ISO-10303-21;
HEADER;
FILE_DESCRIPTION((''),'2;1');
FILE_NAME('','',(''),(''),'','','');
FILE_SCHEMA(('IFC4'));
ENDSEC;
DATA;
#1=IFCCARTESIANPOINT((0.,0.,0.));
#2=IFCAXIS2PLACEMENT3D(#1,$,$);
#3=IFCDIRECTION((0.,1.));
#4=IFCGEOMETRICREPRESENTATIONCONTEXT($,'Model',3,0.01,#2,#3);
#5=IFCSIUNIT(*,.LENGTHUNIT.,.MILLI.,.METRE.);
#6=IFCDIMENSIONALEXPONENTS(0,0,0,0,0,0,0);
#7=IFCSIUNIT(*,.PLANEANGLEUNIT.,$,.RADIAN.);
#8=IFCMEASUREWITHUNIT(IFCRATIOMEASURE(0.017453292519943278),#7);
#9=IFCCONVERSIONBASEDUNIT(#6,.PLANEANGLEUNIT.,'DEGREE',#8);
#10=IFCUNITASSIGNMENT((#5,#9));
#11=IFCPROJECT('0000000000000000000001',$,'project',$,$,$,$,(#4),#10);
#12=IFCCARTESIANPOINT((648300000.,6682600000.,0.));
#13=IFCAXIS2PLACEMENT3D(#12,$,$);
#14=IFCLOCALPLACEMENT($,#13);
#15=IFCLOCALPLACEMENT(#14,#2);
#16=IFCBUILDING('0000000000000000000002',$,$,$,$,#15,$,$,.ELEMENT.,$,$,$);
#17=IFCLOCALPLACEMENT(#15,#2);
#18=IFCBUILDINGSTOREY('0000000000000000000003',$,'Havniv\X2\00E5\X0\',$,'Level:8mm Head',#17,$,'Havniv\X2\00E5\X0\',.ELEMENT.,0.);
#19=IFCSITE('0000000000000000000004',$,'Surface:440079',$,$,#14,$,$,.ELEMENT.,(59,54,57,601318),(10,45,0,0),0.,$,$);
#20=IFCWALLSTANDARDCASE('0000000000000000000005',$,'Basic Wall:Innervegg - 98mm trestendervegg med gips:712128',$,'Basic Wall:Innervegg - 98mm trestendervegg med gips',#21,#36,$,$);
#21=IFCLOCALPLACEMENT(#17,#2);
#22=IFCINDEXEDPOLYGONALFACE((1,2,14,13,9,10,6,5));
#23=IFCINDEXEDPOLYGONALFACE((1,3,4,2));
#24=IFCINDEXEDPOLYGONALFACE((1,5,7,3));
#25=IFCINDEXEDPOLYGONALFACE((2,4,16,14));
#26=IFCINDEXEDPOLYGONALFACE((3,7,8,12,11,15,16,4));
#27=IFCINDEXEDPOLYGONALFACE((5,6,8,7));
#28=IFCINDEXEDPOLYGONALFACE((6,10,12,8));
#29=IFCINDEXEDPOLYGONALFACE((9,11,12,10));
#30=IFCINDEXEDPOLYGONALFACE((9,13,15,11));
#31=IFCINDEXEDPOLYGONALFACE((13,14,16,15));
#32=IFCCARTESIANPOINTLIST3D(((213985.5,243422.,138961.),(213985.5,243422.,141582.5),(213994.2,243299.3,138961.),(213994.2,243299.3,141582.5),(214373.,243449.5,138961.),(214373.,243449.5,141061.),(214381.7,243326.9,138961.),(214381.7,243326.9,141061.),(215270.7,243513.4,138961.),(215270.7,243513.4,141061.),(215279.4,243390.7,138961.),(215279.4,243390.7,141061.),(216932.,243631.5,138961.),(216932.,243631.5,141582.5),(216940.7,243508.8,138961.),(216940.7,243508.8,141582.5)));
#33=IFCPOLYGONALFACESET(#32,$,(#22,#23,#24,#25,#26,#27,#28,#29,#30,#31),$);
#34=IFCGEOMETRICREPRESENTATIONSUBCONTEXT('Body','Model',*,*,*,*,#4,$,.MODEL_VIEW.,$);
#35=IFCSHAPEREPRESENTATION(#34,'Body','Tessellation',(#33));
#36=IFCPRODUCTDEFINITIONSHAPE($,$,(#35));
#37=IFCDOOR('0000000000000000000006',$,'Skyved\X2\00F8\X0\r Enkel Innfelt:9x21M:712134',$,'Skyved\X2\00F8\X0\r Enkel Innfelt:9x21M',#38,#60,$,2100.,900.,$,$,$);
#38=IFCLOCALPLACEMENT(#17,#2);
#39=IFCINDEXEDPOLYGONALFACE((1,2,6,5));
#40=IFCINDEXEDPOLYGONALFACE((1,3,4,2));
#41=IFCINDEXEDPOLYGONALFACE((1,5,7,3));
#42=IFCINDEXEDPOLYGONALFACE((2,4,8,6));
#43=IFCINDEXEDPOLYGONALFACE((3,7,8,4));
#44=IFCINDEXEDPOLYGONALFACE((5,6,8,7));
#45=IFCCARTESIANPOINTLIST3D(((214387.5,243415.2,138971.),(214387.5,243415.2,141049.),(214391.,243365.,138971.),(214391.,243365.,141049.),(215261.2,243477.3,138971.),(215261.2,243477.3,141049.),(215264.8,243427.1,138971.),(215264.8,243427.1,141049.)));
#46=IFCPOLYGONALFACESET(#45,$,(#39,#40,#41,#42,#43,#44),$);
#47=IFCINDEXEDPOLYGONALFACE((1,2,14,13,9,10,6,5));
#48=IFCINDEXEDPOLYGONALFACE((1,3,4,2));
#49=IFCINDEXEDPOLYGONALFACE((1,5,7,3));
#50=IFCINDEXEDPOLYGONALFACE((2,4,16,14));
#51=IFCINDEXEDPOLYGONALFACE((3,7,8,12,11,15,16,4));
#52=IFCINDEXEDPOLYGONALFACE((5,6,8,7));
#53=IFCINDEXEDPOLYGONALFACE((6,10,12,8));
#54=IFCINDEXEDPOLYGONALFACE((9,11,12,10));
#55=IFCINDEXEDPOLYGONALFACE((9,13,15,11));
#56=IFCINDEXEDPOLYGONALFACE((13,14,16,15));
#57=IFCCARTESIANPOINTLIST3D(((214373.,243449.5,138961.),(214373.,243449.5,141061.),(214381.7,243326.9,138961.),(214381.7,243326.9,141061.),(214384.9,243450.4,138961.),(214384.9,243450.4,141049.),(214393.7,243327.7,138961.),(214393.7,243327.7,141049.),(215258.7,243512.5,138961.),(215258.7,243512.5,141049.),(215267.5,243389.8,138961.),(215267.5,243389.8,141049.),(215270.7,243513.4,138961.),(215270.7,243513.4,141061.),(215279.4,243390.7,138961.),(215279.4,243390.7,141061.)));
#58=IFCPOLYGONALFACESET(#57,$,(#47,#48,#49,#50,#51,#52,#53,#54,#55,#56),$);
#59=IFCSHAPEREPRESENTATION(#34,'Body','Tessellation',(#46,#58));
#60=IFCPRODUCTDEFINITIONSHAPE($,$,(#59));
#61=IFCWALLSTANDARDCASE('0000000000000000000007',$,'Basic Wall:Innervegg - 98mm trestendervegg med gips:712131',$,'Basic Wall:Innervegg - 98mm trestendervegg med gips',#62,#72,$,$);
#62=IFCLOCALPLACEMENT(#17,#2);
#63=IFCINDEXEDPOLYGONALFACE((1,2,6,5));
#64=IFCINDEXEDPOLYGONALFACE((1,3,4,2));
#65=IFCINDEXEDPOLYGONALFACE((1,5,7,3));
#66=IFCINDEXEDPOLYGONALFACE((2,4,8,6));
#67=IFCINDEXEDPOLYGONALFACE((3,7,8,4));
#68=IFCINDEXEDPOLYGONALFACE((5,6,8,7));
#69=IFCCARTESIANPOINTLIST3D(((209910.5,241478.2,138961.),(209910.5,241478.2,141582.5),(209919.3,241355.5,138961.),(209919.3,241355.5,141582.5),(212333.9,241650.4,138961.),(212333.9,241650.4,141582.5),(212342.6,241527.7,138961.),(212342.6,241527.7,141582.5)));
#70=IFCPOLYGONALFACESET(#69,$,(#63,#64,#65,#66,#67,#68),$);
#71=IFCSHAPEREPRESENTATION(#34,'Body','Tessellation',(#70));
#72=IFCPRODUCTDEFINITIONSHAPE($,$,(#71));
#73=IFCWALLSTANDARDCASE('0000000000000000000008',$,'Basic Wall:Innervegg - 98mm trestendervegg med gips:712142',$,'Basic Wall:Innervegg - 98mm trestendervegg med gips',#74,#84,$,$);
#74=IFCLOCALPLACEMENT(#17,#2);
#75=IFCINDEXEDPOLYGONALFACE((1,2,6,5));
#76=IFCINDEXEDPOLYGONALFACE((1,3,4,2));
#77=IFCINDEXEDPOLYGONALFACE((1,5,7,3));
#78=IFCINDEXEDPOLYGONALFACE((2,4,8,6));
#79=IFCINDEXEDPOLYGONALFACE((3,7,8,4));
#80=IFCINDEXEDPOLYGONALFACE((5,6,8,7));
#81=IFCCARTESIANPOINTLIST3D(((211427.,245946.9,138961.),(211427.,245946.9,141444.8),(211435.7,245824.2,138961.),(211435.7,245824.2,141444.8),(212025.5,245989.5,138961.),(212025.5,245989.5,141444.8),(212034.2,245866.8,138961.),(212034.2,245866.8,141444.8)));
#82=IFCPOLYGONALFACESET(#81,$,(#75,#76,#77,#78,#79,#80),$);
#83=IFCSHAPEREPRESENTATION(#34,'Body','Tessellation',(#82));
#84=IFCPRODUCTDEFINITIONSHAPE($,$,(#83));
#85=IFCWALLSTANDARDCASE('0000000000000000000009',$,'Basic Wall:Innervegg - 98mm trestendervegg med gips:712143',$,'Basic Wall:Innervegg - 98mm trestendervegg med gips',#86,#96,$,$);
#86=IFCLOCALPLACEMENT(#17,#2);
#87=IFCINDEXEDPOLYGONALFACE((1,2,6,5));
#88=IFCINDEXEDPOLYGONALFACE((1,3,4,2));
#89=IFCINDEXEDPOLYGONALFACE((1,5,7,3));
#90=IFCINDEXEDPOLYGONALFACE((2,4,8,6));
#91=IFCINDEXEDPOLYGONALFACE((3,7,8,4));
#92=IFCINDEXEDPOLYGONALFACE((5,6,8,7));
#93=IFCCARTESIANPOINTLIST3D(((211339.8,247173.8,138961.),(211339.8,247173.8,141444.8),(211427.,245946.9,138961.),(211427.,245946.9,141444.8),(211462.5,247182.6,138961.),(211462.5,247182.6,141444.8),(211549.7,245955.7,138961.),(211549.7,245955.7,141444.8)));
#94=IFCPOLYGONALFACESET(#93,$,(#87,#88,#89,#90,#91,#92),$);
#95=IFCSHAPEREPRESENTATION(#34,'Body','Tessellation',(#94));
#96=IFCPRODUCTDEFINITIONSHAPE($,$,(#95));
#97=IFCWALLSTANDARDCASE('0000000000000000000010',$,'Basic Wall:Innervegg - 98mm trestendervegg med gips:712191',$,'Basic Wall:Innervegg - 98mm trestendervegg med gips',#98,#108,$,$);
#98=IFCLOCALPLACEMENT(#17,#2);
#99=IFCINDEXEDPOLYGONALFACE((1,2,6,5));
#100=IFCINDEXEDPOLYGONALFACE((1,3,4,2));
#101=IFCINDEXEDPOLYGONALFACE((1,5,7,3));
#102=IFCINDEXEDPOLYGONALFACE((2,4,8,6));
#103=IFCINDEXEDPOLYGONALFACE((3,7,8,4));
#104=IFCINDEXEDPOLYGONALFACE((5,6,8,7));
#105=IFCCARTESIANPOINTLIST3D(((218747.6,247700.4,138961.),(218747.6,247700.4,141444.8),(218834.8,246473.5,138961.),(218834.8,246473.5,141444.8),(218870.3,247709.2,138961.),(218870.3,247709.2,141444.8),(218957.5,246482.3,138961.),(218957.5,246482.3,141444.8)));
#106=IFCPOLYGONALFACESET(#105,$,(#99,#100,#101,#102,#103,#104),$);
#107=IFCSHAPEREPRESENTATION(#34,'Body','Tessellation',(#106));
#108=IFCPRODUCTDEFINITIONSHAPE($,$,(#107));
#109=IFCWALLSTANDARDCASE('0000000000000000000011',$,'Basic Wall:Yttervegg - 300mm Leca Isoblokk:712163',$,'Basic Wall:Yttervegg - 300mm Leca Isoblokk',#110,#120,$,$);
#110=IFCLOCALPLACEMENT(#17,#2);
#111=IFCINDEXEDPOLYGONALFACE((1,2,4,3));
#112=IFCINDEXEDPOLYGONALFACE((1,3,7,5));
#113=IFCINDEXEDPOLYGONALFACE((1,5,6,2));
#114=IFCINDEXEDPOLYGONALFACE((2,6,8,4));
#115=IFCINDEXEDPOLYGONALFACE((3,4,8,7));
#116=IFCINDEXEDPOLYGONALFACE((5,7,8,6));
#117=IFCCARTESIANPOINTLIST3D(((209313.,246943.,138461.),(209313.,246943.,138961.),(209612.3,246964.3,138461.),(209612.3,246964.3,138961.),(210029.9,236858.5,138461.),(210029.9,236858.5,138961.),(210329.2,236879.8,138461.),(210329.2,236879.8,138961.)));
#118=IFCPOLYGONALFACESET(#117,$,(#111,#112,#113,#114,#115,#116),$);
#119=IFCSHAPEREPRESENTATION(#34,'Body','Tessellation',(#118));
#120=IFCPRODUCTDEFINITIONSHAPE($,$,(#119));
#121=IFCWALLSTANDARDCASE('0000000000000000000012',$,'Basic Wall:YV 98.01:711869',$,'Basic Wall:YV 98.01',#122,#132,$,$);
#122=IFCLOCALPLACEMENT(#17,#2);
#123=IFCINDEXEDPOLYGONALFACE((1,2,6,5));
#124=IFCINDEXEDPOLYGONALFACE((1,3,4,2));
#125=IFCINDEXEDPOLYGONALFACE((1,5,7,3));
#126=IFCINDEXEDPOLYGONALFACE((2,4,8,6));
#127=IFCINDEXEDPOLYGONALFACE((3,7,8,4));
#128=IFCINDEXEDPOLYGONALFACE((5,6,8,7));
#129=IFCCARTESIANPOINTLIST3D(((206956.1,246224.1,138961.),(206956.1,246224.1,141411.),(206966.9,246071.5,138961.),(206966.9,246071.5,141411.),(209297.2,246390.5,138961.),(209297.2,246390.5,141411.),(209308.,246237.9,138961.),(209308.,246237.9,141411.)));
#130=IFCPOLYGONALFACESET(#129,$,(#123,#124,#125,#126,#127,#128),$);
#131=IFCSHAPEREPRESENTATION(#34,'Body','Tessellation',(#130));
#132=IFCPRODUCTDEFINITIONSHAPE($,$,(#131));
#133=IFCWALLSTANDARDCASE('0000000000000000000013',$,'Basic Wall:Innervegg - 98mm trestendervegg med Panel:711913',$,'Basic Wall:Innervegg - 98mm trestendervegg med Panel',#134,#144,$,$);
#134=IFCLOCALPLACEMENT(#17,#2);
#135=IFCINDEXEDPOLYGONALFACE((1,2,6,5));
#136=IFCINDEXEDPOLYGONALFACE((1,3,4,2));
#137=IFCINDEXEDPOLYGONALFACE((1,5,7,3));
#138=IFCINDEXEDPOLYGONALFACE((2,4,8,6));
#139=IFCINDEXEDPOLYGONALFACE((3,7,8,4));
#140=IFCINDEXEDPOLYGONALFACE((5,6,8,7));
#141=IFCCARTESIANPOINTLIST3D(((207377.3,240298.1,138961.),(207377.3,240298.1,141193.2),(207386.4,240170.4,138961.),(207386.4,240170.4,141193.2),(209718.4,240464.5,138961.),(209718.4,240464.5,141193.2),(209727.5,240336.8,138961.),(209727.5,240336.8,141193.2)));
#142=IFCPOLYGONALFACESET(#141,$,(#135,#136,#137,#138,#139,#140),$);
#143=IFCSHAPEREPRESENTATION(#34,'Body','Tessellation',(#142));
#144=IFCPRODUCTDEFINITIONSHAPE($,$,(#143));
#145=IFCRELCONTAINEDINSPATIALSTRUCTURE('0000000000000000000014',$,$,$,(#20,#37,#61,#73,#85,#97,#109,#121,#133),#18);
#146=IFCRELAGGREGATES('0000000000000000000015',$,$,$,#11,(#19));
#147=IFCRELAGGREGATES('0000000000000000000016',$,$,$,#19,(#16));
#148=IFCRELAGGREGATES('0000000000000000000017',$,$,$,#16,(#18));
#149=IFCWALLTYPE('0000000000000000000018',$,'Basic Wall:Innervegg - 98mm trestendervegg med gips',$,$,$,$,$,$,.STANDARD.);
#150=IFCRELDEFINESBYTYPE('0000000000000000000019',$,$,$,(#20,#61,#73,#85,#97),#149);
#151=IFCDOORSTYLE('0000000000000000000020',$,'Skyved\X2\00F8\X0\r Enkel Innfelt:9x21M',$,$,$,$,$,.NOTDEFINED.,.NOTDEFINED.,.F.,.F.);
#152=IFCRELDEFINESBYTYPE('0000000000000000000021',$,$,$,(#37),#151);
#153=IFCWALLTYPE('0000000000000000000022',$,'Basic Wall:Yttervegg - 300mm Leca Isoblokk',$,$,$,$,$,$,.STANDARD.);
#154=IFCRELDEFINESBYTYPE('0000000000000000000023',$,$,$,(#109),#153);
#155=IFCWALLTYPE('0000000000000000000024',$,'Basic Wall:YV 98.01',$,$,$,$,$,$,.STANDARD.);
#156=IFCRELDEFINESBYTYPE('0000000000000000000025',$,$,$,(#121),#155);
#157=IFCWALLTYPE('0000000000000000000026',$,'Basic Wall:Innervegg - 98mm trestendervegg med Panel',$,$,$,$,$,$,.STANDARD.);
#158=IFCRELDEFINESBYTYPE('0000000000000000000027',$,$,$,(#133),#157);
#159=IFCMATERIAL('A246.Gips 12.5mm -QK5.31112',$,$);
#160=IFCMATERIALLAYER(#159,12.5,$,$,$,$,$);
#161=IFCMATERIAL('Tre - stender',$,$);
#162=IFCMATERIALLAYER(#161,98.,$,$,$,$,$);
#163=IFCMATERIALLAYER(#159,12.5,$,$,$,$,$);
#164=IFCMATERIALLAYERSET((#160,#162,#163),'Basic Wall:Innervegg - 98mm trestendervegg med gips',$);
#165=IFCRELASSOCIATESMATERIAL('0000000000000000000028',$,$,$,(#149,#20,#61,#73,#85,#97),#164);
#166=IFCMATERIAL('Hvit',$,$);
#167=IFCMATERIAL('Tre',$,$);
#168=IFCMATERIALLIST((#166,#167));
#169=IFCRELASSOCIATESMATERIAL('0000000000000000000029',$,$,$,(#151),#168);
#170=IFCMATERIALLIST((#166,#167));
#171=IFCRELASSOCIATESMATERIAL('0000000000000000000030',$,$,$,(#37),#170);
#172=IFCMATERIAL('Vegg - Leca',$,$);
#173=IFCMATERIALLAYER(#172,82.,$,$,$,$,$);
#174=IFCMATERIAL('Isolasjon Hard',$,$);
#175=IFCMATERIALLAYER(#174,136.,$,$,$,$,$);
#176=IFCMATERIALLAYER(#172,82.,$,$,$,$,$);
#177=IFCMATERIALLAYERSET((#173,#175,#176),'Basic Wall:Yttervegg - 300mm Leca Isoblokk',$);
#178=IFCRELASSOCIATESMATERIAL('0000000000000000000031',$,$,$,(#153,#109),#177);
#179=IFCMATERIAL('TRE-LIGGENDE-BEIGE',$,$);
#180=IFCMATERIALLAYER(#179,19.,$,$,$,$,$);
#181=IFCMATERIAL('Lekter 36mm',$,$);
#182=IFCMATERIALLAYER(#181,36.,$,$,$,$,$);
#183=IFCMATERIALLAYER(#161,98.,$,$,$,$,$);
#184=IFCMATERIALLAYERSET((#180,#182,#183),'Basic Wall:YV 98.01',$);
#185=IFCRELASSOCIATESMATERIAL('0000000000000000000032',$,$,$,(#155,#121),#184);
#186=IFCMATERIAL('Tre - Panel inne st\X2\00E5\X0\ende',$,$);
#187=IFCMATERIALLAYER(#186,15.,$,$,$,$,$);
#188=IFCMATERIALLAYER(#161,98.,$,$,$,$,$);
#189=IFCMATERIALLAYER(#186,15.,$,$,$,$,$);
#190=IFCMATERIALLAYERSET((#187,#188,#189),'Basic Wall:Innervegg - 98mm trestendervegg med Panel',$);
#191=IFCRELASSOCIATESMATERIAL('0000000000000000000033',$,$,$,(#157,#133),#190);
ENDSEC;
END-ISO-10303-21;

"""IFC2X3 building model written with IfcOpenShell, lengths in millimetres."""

from ifc_helpers import new_model, entity, si_unit, converted_unit, direction, frame, frame_2d, origin, place, context, subcontext, project, spatial, polyline, rectangle, outline, extrude, clip, bounded_halfspace, source, transform, mapped, material, material_list, layer, layer_set, layer_usage, type_object, type_shapes, element, fill, save


model = new_model("IFC2X3")

# Units and contexts
model_context = context("Model", 3, precision=0.01, world=origin(), true_north=direction((0.0, 1.0)))
body_context = subcontext(model_context, "Body", "Model", "MODEL_VIEW")
ifc_project = project(units=[si_unit("LENGTHUNIT", "METRE", prefix="MILLI"), converted_unit("PLANEANGLEUNIT", "DEGREE", entity("IfcRatioMeasure", 0.017453292519943278), si_unit("PLANEANGLEUNIT", "RADIAN"), dimensions=[0, 0, 0, 0, 0, 0, 0])], contexts=[model_context])

# Site, building, storey
site_placement = place(None, frame((648300000.0, 6682600000.0, 0.0)))
site = spatial("IfcSite", under=ifc_project, at=site_placement, Name="Surface:440079", CompositionType="ELEMENT", RefLatitude=(59, 54, 57, 601318), RefLongitude=(10, 45, 0, 0), RefElevation=0.0)
building_placement = place(site_placement, origin())
building = spatial("IfcBuilding", under=site, at=building_placement, CompositionType="ELEMENT")
storey_placement = place(building_placement, origin())
storey = spatial("IfcBuildingStorey", under=building, at=storey_placement, Name="Havnivå", ObjectType="Level:8mm Head", LongName="Havnivå", CompositionType="ELEMENT", Elevation=0.0)

# Shared definitions
ifc_material_1 = material(Name="TRE-LIGGENDE-BEIGE")
ifc_material_2 = material(Name="Lekter 36mm")
ifc_material_3 = material(Name="A246.Gips 12.5mm -QK5.31112")

# Shared definitions
ifc_layer_1 = layer(ifc_material_3, 12.5)
ifc_material_4 = material(Name="Tre - stender")
ifc_layer_2 = layer(ifc_material_4, 98.0)
ifc_layer_3 = layer(ifc_material_3, 12.5)
ifc_layer_set_1 = layer_set([ifc_layer_1, ifc_layer_2, ifc_layer_3], Name="Basic Wall:Innervegg - 98mm trestendervegg med gips")
wall_type_1 = type_object("IfcWallType", Name="Basic Wall:Innervegg - 98mm trestendervegg med gips", PredefinedType="STANDARD", material=ifc_layer_set_1)
ifc_material_5 = material(Name="Hvit")
ifc_material_6 = material(Name="Tre")

# Wall, opening, door
ifc_layer_usage_1 = layer_usage(ifc_layer_set_1, "AXIS2", "POSITIVE", -61.5)
wall_1_placement = place(storey_placement, frame((213989.8, 243360.7, 138961.0), z_axis=(0.0, 0.0, 1.0), x_axis=(0.997483, 0.070908, 0.0)))
wall_1 = element("IfcWallStandardCase", 1, at=wall_1_placement, inside=storey, type_object=wall_type_1, material=ifc_layer_usage_1, Name="Basic Wall:Innervegg - 98mm trestendervegg med gips:712128", ObjectType="Basic Wall:Innervegg - 98mm trestendervegg med gips", context=body_context, shape_type="SweptSolid", body=[
    extrude(rectangle(XDim=2954.0, YDim=123.0, at=frame_2d((1477.0, 0.0), x_axis=(1.0, 0.0))), origin(), (0.0, 0.0, 1.0), 2621.5),
])
opening_1_placement = place(wall_1_placement, frame((388.5, -61.5, 0.0)))
opening_1 = element("IfcOpeningElement", 2, at=opening_1_placement, cuts=wall_1, ObjectType="Opening", context=body_context, shape_type="SweptSolid", body=[
    extrude(rectangle(XDim=2100.0, YDim=900.0, at=frame_2d((1050.0, 450.0), x_axis=(1.0, 0.0))), frame((0.0, 0.0, 0.0), z_axis=(0.0, 1.0, 0.0), x_axis=(0.0, 0.0, 1.0)), (0.0, 0.0, 1.0), 123.0),
])
ifc_material_list_1 = material_list([ifc_material_5, ifc_material_6])
ifc_material_list_2 = material_list([ifc_material_5, ifc_material_6])
door_style_1 = type_object("IfcDoorStyle", Name="Skyvedør Enkel Innfelt:9x21M", ConstructionType="NOTDEFINED", OperationType="NOTDEFINED", ParameterTakesPrecedence=False, Sizeable=False, material=ifc_material_list_2)
shared_shape_1 = source(origin(), body_context, "Body", "SweptSolid", [
    extrude(rectangle(XDim=50.4, YDim=876.0, at=frame_2d((0.0, 0.0), x_axis=(1.0, 0.0))), frame((450.0, 60.5, 10.0), z_axis=(0.0, 0.0, 1.0), x_axis=(0.0, -1.0, 0.0)), (0.0, 0.0, 1.0), 2078.0),
    extrude(outline(polyline([(-450.0, -1047.0), (-438.0, -1047.0), (-438.0, 1041.0), (438.0, 1041.0), (438.0, -1047.0), (450.0, -1047.0), (450.0, 1053.0), (-450.0, 1053.0), (-450.0, -1047.0)])), frame((450.0, 120.9, 1047.0), z_axis=(0.0, -1.0, 0.0), x_axis=(1.0, 0.0, 0.0)), (0.0, 0.0, 1.0), 123.0),
])
type_shapes(door_style_1, [shared_shape_1])
door_1_placement = place(opening_1_placement, frame((0.0, 2.1, 0.0)))
door_1 = element("IfcDoor", 3, at=door_1_placement, inside=storey, type_object=door_style_1, material=ifc_material_list_1, Name="Skyvedør Enkel Innfelt:9x21M:712134", ObjectType="Skyvedør Enkel Innfelt:9x21M", OverallHeight=2100.0, OverallWidth=900.0, context=body_context, shape_type="MappedRepresentation", body=[
    mapped(shared_shape_1, transform((0.0, 0.0, 0.0), scale=1.0)),
])
fill(opening_1, door_1)

# Walls
ifc_layer_usage_2 = layer_usage(ifc_layer_set_1, "AXIS2", "NEGATIVE", 61.5)
wall_2_placement = place(storey_placement, frame((212338.3, 241589.1, 138961.0), z_axis=(0.0, 0.0, 1.0), x_axis=(-0.997483, -0.070908, 0.0)))
element("IfcWallStandardCase", 4, at=wall_2_placement, inside=storey, type_object=wall_type_1, material=ifc_layer_usage_2, Name="Basic Wall:Innervegg - 98mm trestendervegg med gips:712131", ObjectType="Basic Wall:Innervegg - 98mm trestendervegg med gips", context=body_context, shape_type="Clipping", body=[
    clip(extrude(rectangle(XDim=2429.5, YDim=123.0, at=frame_2d((1214.8, 0.0), x_axis=(-1.0, 0.0))), origin(), (0.0, 0.0, 1.0), 2621.5), bounded_halfspace(frame((0.0, -61.5, 2621.5), z_axis=(0.0, 0.0, -1.0), x_axis=(1.0, 0.0, 0.0)), True, frame((0.0, -61.5, 2621.5)), polyline([(0.0, 0.0), (740511.6, 0.0), (740511.6, 37490.4), (0.0, 37490.4), (0.0, 0.0)]))),
])
ifc_layer_usage_3 = layer_usage(ifc_layer_set_1, "AXIS2", "POSITIVE", -61.5)
wall_3_placement = place(storey_placement, frame((212029.8, 245928.1, 138961.0), z_axis=(0.0, 0.0, 1.0), x_axis=(-0.997483, -0.070908, 0.0)))
element("IfcWallStandardCase", 5, at=wall_3_placement, inside=storey, type_object=wall_type_1, material=ifc_layer_usage_3, Name="Basic Wall:Innervegg - 98mm trestendervegg med gips:712142", ObjectType="Basic Wall:Innervegg - 98mm trestendervegg med gips", context=body_context, shape_type="SweptSolid", body=[
    extrude(rectangle(XDim=600.0, YDim=123.0, at=frame_2d((300.0, 0.0), x_axis=(-1.0, 0.0))), origin(), (0.0, 0.0, 1.0), 2483.8),
])
ifc_layer_usage_4 = layer_usage(ifc_layer_set_1, "AXIS2", "POSITIVE", -61.5)
wall_4_placement = place(storey_placement, frame((211488.3, 245951.3, 138961.0), z_axis=(0.0, 0.0, 1.0), x_axis=(-0.070908, 0.997483, 0.0)))
element("IfcWallStandardCase", 6, at=wall_4_placement, inside=storey, type_object=wall_type_1, material=ifc_layer_usage_4, Name="Basic Wall:Innervegg - 98mm trestendervegg med gips:712143", ObjectType="Basic Wall:Innervegg - 98mm trestendervegg med gips", context=body_context, shape_type="SweptSolid", body=[
    extrude(rectangle(XDim=1230.0, YDim=123.0, at=frame_2d((615.0, 0.0), x_axis=(-1.0, 0.0))), origin(), (0.0, 0.0, 1.0), 2483.8),
])
ifc_layer_usage_5 = layer_usage(ifc_layer_set_1, "AXIS2", "POSITIVE", -61.5)
wall_5_placement = place(storey_placement, frame((218896.1, 246477.9, 138961.0), z_axis=(0.0, 0.0, 1.0), x_axis=(-0.070908, 0.997483, 0.0)))
element("IfcWallStandardCase", 7, at=wall_5_placement, inside=storey, type_object=wall_type_1, material=ifc_layer_usage_5, Name="Basic Wall:Innervegg - 98mm trestendervegg med gips:712191", ObjectType="Basic Wall:Innervegg - 98mm trestendervegg med gips", context=body_context, shape_type="SweptSolid", body=[
    extrude(rectangle(XDim=1230.0, YDim=123.0, at=frame_2d((615.0, 0.0), x_axis=(-1.0, 0.0))), origin(), (0.0, 0.0, 1.0), 2483.8),
])
ifc_material_7 = material(Name="Vegg - Leca")
ifc_layer_4 = layer(ifc_material_7, 82.0)
ifc_material_8 = material(Name="Isolasjon Hard")
ifc_layer_5 = layer(ifc_material_8, 136.0)
ifc_layer_6 = layer(ifc_material_7, 82.0)
ifc_layer_set_2 = layer_set([ifc_layer_4, ifc_layer_5, ifc_layer_6], Name="Basic Wall:Yttervegg - 300mm Leca Isoblokk")
ifc_layer_usage_6 = layer_usage(ifc_layer_set_2, "AXIS2", "POSITIVE", -150.0)
wall_type_2 = type_object("IfcWallType", Name="Basic Wall:Yttervegg - 300mm Leca Isoblokk", PredefinedType="STANDARD", material=ifc_layer_set_2)
wall_6_placement = place(storey_placement, frame((209462.6, 246953.7, 138461.0), z_axis=(0.0, 0.0, 1.0), x_axis=(0.070908, -0.997483, 0.0)))
element("IfcWallStandardCase", 8, at=wall_6_placement, inside=storey, type_object=wall_type_2, material=ifc_layer_usage_6, Name="Basic Wall:Yttervegg - 300mm Leca Isoblokk:712163", ObjectType="Basic Wall:Yttervegg - 300mm Leca Isoblokk", context=body_context, shape_type="SweptSolid", body=[
    extrude(rectangle(XDim=10110.0, YDim=300.0, at=frame_2d((5055.0, 0.0), x_axis=(-1.0, 0.0))), origin(), (0.0, 0.0, 1.0), 500.0),
])
ifc_layer_7 = layer(ifc_material_1, 19.0)
ifc_layer_8 = layer(ifc_material_2, 36.0)
ifc_layer_9 = layer(ifc_material_4, 98.0)
ifc_layer_set_3 = layer_set([ifc_layer_7, ifc_layer_8, ifc_layer_9], Name="Basic Wall:YV 98.01")
ifc_layer_usage_7 = layer_usage(ifc_layer_set_3, "AXIS2", "POSITIVE", -76.5)
wall_type_3 = type_object("IfcWallType", Name="Basic Wall:YV 98.01", PredefinedType="STANDARD", material=ifc_layer_set_3)
wall_7_placement = place(storey_placement, frame((209302.6, 246314.2, 138961.0), z_axis=(0.0, 0.0, 1.0), x_axis=(-0.997483, -0.070908, 0.0)))
element("IfcWallStandardCase", 9, at=wall_7_placement, inside=storey, type_object=wall_type_3, material=ifc_layer_usage_7, Name="Basic Wall:YV 98.01:711869", ObjectType="Basic Wall:YV 98.01", context=body_context, shape_type="SweptSolid", body=[
    extrude(rectangle(XDim=2347.0, YDim=153.0, at=frame_2d((1173.5, 0.0), x_axis=(-1.0, 0.0))), origin(), (0.0, 0.0, 1.0), 2450.0),
])
ifc_material_9 = material(Name="Tre - Panel inne stående")
ifc_layer_10 = layer(ifc_material_9, 15.0)
ifc_layer_11 = layer(ifc_material_4, 98.0)
ifc_layer_12 = layer(ifc_material_9, 15.0)
ifc_layer_set_4 = layer_set([ifc_layer_10, ifc_layer_11, ifc_layer_12], Name="Basic Wall:Innervegg - 98mm trestendervegg med Panel")
ifc_layer_usage_8 = layer_usage(ifc_layer_set_4, "AXIS2", "NEGATIVE", 64.0)
wall_type_4 = type_object("IfcWallType", Name="Basic Wall:Innervegg - 98mm trestendervegg med Panel", PredefinedType="STANDARD", material=ifc_layer_set_4)
wall_8_placement = place(storey_placement, frame((207381.9, 240234.2, 138961.0), z_axis=(0.0, 0.0, 1.0), x_axis=(0.997483, 0.070908, 0.0)))
element("IfcWallStandardCase", 10, at=wall_8_placement, inside=storey, type_object=wall_type_4, material=ifc_layer_usage_8, Name="Basic Wall:Innervegg - 98mm trestendervegg med Panel:711913", ObjectType="Basic Wall:Innervegg - 98mm trestendervegg med Panel", context=body_context, shape_type="Clipping", body=[
    clip(extrude(rectangle(XDim=2347.0, YDim=128.0, at=frame_2d((1173.5, 0.0), x_axis=(-1.0, 0.0))), origin(), (0.0, 0.0, 1.0), 2232.2), bounded_halfspace(frame((0.0, -64.0, 2232.2), z_axis=(0.0, 0.0, -1.0), x_axis=(1.0, 0.0, 0.0)), True, frame((0.0, -64.0, 2232.2)), polyline([(0.0, 0.0), (715365.6, 0.0), (715365.6, 39014.4), (0.0, 39014.4), (0.0, 0.0)]))),
])

save(model, "model.ifc")
